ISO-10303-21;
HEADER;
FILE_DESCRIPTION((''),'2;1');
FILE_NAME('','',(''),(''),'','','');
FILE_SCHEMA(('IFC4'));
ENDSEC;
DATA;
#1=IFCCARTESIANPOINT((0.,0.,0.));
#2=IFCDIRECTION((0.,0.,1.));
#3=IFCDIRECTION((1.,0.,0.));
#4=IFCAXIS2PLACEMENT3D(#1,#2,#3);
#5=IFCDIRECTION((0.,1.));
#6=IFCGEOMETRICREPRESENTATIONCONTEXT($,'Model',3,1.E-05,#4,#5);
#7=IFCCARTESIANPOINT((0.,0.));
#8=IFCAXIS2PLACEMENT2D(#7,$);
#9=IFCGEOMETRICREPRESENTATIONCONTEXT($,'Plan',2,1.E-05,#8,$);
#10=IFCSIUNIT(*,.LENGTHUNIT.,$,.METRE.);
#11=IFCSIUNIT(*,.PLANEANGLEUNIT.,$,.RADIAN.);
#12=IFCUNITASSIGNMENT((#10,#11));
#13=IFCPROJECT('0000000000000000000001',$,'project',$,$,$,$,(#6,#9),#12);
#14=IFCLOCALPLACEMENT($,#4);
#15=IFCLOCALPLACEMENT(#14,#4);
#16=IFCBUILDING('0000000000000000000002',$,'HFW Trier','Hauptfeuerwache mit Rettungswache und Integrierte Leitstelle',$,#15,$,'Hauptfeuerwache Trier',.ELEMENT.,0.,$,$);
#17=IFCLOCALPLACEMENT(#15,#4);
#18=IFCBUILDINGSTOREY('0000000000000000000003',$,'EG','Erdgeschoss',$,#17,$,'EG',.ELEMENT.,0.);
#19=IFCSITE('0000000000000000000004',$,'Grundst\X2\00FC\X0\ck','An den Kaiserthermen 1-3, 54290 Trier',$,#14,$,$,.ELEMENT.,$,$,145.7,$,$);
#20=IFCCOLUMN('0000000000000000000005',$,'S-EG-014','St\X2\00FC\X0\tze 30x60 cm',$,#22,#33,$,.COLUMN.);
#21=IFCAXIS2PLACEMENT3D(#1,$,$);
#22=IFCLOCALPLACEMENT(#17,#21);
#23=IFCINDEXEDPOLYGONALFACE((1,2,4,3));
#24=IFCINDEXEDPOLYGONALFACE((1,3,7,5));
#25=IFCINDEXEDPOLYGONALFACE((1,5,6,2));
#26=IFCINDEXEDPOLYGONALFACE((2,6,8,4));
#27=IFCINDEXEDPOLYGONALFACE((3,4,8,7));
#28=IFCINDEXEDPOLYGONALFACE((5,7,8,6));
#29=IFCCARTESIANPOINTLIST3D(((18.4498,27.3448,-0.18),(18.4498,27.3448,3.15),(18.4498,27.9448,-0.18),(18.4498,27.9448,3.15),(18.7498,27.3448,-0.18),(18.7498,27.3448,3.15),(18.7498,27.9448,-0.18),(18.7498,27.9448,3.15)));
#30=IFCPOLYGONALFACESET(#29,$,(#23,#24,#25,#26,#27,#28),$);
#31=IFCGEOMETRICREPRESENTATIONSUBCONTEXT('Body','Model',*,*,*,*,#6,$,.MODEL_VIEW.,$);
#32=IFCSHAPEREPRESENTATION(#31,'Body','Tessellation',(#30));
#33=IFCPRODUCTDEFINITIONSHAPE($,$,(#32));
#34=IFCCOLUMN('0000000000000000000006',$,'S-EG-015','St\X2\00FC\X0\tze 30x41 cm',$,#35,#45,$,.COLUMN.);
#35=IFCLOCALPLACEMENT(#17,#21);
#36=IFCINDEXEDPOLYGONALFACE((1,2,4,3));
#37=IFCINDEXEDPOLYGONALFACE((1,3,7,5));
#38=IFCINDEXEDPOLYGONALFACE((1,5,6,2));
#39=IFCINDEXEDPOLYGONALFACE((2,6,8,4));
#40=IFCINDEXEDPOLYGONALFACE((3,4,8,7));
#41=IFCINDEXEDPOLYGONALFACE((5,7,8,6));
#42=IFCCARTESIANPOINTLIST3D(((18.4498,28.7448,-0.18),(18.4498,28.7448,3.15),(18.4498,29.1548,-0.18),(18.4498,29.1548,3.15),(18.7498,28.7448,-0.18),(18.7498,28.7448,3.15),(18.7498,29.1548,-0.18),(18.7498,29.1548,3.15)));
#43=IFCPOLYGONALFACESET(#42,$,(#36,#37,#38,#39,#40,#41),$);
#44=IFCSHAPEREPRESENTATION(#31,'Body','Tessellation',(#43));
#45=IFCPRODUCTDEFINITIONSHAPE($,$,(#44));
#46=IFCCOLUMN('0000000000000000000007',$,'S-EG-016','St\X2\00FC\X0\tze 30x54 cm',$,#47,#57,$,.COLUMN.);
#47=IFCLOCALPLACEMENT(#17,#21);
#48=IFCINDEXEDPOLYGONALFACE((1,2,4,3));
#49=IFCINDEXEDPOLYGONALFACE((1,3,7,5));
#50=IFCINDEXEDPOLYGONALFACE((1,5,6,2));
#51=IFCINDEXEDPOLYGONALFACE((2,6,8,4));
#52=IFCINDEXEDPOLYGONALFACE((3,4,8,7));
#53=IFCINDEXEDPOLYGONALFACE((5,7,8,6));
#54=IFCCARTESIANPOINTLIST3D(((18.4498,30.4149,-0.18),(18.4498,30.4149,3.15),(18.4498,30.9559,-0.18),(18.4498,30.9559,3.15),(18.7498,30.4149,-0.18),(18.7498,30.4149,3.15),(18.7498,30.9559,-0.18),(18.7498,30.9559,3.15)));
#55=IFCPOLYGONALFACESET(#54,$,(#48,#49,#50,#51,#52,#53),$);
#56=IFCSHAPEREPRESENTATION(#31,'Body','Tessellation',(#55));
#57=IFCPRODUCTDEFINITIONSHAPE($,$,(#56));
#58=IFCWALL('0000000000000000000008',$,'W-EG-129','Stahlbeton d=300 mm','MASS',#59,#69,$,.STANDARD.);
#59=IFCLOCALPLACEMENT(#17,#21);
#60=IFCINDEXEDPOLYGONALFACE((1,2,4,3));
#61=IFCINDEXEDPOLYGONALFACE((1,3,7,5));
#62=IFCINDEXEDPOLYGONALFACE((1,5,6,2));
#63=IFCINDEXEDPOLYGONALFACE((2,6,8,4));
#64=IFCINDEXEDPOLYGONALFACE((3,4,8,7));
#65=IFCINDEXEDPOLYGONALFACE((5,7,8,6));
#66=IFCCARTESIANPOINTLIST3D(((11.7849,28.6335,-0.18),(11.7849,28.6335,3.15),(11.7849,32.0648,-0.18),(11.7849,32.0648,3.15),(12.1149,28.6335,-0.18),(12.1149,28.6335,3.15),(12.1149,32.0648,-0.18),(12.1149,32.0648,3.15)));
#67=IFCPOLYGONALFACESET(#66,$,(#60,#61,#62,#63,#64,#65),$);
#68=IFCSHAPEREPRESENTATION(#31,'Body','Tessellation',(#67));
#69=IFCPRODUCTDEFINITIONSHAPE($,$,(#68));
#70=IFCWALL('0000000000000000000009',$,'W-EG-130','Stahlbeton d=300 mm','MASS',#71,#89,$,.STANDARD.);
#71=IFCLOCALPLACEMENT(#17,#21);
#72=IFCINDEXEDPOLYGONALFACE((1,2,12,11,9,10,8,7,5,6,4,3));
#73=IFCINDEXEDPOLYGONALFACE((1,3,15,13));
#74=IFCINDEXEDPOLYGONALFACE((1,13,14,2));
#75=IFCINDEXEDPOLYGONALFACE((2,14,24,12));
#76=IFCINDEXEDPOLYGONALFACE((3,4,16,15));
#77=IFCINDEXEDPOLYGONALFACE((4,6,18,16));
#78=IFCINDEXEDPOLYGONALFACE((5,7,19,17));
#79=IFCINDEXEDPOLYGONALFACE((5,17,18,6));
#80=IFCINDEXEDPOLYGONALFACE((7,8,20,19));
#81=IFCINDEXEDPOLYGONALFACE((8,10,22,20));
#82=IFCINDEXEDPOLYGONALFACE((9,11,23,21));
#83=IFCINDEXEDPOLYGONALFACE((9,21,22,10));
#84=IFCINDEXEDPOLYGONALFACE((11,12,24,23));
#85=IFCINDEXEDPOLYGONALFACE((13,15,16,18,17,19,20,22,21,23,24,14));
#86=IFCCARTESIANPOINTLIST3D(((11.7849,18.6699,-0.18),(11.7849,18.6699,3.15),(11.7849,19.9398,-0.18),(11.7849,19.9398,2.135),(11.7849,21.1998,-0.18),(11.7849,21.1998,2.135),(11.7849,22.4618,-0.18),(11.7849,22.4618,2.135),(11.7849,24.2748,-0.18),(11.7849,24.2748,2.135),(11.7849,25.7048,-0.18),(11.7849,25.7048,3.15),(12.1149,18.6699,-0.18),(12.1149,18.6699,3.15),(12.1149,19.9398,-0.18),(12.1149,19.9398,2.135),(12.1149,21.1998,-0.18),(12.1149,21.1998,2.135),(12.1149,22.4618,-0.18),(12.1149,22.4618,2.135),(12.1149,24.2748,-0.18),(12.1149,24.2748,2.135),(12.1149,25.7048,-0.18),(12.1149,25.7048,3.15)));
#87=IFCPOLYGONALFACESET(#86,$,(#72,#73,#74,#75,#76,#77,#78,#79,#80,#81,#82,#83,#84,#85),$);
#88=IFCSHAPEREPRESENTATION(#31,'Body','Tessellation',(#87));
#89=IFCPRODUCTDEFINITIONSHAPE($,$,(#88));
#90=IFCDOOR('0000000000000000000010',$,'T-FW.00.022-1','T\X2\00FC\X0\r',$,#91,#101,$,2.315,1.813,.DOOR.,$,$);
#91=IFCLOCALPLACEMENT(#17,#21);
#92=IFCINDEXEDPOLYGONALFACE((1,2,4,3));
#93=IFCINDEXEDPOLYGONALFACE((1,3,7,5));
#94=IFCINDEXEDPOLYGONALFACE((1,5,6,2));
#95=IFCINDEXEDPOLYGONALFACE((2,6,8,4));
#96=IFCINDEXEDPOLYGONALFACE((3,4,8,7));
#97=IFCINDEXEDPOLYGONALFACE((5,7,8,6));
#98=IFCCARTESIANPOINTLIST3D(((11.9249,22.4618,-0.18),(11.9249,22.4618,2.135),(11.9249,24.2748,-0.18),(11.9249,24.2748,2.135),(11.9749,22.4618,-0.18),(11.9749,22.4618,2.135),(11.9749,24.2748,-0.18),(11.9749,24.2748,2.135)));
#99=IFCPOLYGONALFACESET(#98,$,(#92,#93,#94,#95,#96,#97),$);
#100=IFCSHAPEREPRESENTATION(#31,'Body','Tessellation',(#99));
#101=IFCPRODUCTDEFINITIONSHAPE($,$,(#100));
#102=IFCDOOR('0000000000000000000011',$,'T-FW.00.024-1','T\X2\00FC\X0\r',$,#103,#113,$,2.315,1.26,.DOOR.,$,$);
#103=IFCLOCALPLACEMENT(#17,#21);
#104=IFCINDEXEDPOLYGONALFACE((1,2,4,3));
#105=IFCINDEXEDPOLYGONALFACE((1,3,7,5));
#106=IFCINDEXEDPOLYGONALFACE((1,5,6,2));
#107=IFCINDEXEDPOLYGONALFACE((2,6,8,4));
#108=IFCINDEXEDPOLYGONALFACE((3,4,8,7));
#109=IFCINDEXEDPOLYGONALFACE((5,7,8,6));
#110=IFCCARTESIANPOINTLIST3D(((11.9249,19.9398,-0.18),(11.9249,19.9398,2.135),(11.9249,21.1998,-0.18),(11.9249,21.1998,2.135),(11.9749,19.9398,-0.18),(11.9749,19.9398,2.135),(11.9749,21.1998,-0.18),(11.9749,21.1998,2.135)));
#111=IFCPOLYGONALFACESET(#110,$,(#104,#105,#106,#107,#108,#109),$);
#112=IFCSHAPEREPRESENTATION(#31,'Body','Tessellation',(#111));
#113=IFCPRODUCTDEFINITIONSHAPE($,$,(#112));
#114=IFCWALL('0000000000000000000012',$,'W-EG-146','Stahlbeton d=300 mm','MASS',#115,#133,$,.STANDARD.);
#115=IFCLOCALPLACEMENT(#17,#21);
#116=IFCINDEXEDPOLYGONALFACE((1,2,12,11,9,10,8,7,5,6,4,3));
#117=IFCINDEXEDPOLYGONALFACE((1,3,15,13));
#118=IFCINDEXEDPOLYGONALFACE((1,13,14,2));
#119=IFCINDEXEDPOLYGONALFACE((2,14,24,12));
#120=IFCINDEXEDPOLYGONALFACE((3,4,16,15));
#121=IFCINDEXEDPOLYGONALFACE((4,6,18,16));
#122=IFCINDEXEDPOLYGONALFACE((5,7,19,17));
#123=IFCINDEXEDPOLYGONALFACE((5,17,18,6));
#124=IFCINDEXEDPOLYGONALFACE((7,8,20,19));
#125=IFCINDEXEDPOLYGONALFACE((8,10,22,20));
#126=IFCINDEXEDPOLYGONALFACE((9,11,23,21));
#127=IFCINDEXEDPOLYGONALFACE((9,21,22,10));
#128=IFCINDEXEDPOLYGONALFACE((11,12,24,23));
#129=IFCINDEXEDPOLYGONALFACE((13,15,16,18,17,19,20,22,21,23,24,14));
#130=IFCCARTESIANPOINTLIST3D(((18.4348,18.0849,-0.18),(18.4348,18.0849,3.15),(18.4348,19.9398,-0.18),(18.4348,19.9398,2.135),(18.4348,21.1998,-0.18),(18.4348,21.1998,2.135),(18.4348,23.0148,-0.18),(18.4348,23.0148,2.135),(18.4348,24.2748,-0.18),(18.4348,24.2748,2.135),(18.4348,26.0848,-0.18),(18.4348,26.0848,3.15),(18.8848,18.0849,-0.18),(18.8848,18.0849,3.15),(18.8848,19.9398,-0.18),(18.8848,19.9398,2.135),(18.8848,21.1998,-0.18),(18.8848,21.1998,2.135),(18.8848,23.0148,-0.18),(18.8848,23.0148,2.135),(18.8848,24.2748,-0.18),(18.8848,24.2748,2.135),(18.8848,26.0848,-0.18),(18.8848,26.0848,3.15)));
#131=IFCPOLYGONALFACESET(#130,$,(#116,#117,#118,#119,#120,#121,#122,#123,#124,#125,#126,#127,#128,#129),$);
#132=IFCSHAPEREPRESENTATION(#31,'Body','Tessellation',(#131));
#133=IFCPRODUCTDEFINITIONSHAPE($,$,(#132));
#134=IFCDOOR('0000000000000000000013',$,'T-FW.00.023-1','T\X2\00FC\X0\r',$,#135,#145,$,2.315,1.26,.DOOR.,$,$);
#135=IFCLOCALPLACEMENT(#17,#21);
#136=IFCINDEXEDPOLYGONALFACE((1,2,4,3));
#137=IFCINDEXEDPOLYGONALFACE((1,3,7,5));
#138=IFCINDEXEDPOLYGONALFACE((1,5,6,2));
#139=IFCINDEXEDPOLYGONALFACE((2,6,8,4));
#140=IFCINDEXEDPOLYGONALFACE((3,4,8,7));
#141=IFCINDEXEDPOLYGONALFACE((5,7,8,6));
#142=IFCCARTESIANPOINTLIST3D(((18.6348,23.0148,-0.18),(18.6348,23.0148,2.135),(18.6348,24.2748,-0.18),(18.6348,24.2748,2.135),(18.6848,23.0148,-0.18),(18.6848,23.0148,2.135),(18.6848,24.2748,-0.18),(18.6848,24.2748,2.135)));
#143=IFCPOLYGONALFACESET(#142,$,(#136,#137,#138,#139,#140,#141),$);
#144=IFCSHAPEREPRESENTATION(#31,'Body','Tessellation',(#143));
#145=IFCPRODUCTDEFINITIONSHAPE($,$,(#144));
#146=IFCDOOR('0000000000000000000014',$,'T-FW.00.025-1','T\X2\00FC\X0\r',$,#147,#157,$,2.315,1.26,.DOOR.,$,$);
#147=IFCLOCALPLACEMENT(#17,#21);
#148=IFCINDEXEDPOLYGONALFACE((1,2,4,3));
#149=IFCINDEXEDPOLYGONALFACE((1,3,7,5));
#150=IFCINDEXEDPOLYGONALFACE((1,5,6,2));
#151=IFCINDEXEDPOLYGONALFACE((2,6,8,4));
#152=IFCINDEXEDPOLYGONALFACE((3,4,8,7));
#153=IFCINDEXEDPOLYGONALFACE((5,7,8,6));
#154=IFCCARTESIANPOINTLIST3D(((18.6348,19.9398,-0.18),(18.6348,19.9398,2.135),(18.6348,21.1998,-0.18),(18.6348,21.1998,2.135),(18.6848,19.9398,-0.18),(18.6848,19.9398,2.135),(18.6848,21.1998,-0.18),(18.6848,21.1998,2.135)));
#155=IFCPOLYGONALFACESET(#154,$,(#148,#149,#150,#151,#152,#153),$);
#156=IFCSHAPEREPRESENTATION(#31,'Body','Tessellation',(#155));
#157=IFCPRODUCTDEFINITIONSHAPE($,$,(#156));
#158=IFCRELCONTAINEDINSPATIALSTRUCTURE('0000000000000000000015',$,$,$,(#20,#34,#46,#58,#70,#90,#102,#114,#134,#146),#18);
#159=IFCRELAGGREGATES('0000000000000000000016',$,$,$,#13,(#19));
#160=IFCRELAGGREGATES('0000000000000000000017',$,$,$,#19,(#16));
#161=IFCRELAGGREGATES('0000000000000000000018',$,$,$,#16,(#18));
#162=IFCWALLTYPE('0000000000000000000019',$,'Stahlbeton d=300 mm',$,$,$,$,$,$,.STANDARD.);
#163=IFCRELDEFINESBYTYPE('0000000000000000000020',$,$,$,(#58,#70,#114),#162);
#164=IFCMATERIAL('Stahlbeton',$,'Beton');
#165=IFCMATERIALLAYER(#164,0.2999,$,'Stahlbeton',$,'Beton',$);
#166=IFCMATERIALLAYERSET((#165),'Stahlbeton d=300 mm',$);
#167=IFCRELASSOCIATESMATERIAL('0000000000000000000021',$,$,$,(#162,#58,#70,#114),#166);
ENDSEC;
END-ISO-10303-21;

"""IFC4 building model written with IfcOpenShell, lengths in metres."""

from ifc_helpers import new_model, si_unit, direction, frame, frame_2d, origin_with_axes, origin_2d, place, context, subcontext, project, spatial, rectangle, extrude, material, layer, layer_set, layer_usage, type_object, element, fill, save


model = new_model("IFC4")

# Units and contexts
model_context = context("Model", 3, precision=1e-05, world=origin_with_axes(), true_north=direction((0.0, 1.0)))
plan_context = context("Plan", 2, precision=1e-05, world=origin_2d())
body_context = subcontext(model_context, "Body", "Model", "MODEL_VIEW")
ifc_project = project(units=[si_unit("LENGTHUNIT", "METRE"), si_unit("PLANEANGLEUNIT", "RADIAN")], contexts=[model_context, plan_context])

# Site, building, storey
site_placement = place(None, origin_with_axes())
site = spatial("IfcSite", under=ifc_project, at=site_placement, Name="Grundstück", Description="An den Kaiserthermen 1-3, 54290 Trier", CompositionType="ELEMENT", RefElevation=145.7)
building_placement = place(site_placement, origin_with_axes())
building = spatial("IfcBuilding", under=site, at=building_placement, Name="HFW Trier", Description="Hauptfeuerwache mit Rettungswache und Integrierte Leitstelle", LongName="Hauptfeuerwache Trier", CompositionType="ELEMENT", ElevationOfRefHeight=0.0)
storey_placement = place(building_placement, origin_with_axes())
storey = spatial("IfcBuildingStorey", under=building, at=storey_placement, Name="EG", Description="Erdgeschoss", LongName="EG", CompositionType="ELEMENT", Elevation=0.0)

# Columns
column_1_placement = place(storey_placement, frame((18.4498, 27.6448, -0.18), z_axis=(0.0, 0.0, 1.0), x_axis=(1.0, 0.0, 0.0)))
element("IfcColumn", 1, at=column_1_placement, inside=storey, Name="S-EG-014", Description="Stütze 30x60 cm", PredefinedType="COLUMN", context=body_context, shape_type="SweptSolid", body=[
    extrude(rectangle(XDim=0.3, YDim=0.6, at=frame_2d((0.15, 0.0))), origin_with_axes(), (0.0, 0.0, 1.0), 3.33),
])
column_2_placement = place(storey_placement, frame((18.4498, 28.9498, -0.18), z_axis=(0.0, 0.0, 1.0), x_axis=(1.0, 0.0, 0.0)))
element("IfcColumn", 2, at=column_2_placement, inside=storey, Name="S-EG-015", Description="Stütze 30x41 cm", PredefinedType="COLUMN", context=body_context, shape_type="SweptSolid", body=[
    extrude(rectangle(XDim=0.3, YDim=0.41, at=frame_2d((0.15, 0.0))), origin_with_axes(), (0.0, 0.0, 1.0), 3.33),
])
column_3_placement = place(storey_placement, frame((18.4498, 30.6854, -0.18), z_axis=(0.0, 0.0, 1.0), x_axis=(1.0, 0.0, 0.0)))
element("IfcColumn", 3, at=column_3_placement, inside=storey, Name="S-EG-016", Description="Stütze 30x54 cm", PredefinedType="COLUMN", context=body_context, shape_type="SweptSolid", body=[
    extrude(rectangle(XDim=0.3, YDim=0.541, at=frame_2d((0.15, 0.0))), origin_with_axes(), (0.0, 0.0, 1.0), 3.33),
])

# Wall
ifc_material_1 = material(Name="Stahlbeton", Category="Beton")
ifc_layer_1 = layer(ifc_material_1, 0.2999, Name="Stahlbeton", Category="Beton")
ifc_layer_set_1 = layer_set([ifc_layer_1], Name="Stahlbeton d=300 mm")
ifc_layer_usage_1 = layer_usage(ifc_layer_set_1, "AXIS2", "POSITIVE", -0.165)
wall_type_1 = type_object("IfcWallType", Name="Stahlbeton d=300 mm", PredefinedType="STANDARD", material=ifc_layer_set_1)
wall_1_placement = place(storey_placement, frame((11.9499, 32.0648, -0.18), z_axis=(0.0, 0.0, 1.0), x_axis=(0.0, -1.0, 0.0)))
element("IfcWall", 4, at=wall_1_placement, inside=storey, type_object=wall_type_1, material=ifc_layer_usage_1, Name="W-EG-129", Description="Stahlbeton d=300 mm", ObjectType="MASS", PredefinedType="STANDARD", context=body_context, shape_type="SweptSolid", body=[
    extrude(rectangle(XDim=3.4313, YDim=0.33, at=frame_2d((1.7156, 0.0))), origin_with_axes(), (0.0, 0.0, 1.0), 3.33),
])

# Walls, openings, doors
ifc_layer_usage_2 = layer_usage(ifc_layer_set_1, "AXIS2", "POSITIVE", -0.165)
wall_2_placement = place(storey_placement, frame((11.9499, 25.7048, -0.18), z_axis=(0.0, 0.0, 1.0), x_axis=(0.0, -1.0, 0.0)))
wall_2 = element("IfcWall", 5, at=wall_2_placement, inside=storey, type_object=wall_type_1, material=ifc_layer_usage_2, Name="W-EG-130", Description="Stahlbeton d=300 mm", ObjectType="MASS", PredefinedType="STANDARD", context=body_context, shape_type="SweptSolid", body=[
    extrude(rectangle(XDim=7.0349, YDim=0.33, at=frame_2d((3.5175, 0.0))), origin_with_axes(), (0.0, 0.0, 1.0), 3.33),
])
opening_1_placement = place(wall_2_placement, frame((1.43, 0.0, 0.0), z_axis=(0.0, 0.0, 1.0), x_axis=(1.0, 0.0, 0.0)))
opening_1 = element("IfcOpeningElement", 6, at=opening_1_placement, cuts=wall_2, PredefinedType="OPENING", context=body_context, shape_type="SweptSolid", body=[
    extrude(rectangle(XDim=1.813, YDim=0.43, at=frame_2d((0.9065, 0.0))), origin_with_axes(), (0.0, 0.0, 1.0), 2.315),
])
opening_2_placement = place(wall_2_placement, frame((4.505, 0.0, 0.0), z_axis=(0.0, 0.0, 1.0), x_axis=(1.0, 0.0, 0.0)))
opening_2 = element("IfcOpeningElement", 7, at=opening_2_placement, cuts=wall_2, PredefinedType="OPENING", context=body_context, shape_type="SweptSolid", body=[
    extrude(rectangle(XDim=1.26, YDim=0.43, at=frame_2d((0.63, 0.0))), origin_with_axes(), (0.0, 0.0, 1.0), 2.315),
])
door_1_placement = place(wall_2_placement, frame((1.43, 0.0, 0.0), z_axis=(0.0, 0.0, 1.0), x_axis=(1.0, 0.0, 0.0)))
door_1 = element("IfcDoor", 8, at=door_1_placement, inside=storey, Name="T-FW.00.022-1", Description="Tür", OverallHeight=2.315, OverallWidth=1.813, PredefinedType="DOOR", context=body_context, shape_type="SweptSolid", body=[
    extrude(rectangle(XDim=1.813, YDim=0.05, at=frame_2d((0.9065, 0.0))), origin_with_axes(), (0.0, 0.0, 1.0), 2.315),
])
fill(opening_1, door_1)
door_2_placement = place(wall_2_placement, frame((4.505, 0.0, 0.0), z_axis=(0.0, 0.0, 1.0), x_axis=(1.0, 0.0, 0.0)))
door_2 = element("IfcDoor", 9, at=door_2_placement, inside=storey, Name="T-FW.00.024-1", Description="Tür", OverallHeight=2.315, OverallWidth=1.26, PredefinedType="DOOR", context=body_context, shape_type="SweptSolid", body=[
    extrude(rectangle(XDim=1.26, YDim=0.05, at=frame_2d((0.63, 0.0))), origin_with_axes(), (0.0, 0.0, 1.0), 2.315),
])
fill(opening_2, door_2)
ifc_layer_usage_3 = layer_usage(ifc_layer_set_1, "AXIS2", "POSITIVE", -0.225)
wall_3_placement = place(storey_placement, frame((18.6598, 26.0848, -0.18), z_axis=(0.0, 0.0, 1.0), x_axis=(0.0, -1.0, 0.0)))
wall_3 = element("IfcWall", 10, at=wall_3_placement, inside=storey, type_object=wall_type_1, material=ifc_layer_usage_3, Name="W-EG-146", Description="Stahlbeton d=300 mm", ObjectType="MASS", PredefinedType="STANDARD", context=body_context, shape_type="SweptSolid", body=[
    extrude(rectangle(XDim=7.9999, YDim=0.45, at=frame_2d((4.0, 0.0))), origin_with_axes(), (0.0, 0.0, 1.0), 3.33),
])
opening_3_placement = place(wall_3_placement, frame((1.81, 0.0, 0.0), z_axis=(0.0, 0.0, 1.0), x_axis=(1.0, 0.0, 0.0)))
opening_3 = element("IfcOpeningElement", 11, at=opening_3_placement, cuts=wall_3, PredefinedType="OPENING", context=body_context, shape_type="SweptSolid", body=[
    extrude(rectangle(XDim=1.26, YDim=0.55, at=frame_2d((0.63, 0.0))), origin_with_axes(), (0.0, 0.0, 1.0), 2.315),
])
opening_4_placement = place(wall_3_placement, frame((4.885, 0.0, 0.0), z_axis=(0.0, 0.0, 1.0), x_axis=(1.0, 0.0, 0.0)))
opening_4 = element("IfcOpeningElement", 12, at=opening_4_placement, cuts=wall_3, PredefinedType="OPENING", context=body_context, shape_type="SweptSolid", body=[
    extrude(rectangle(XDim=1.26, YDim=0.55, at=frame_2d((0.63, 0.0))), origin_with_axes(), (0.0, 0.0, 1.0), 2.315),
])
door_3_placement = place(wall_3_placement, frame((1.81, 0.0, 0.0), z_axis=(0.0, 0.0, 1.0), x_axis=(1.0, 0.0, 0.0)))
door_3 = element("IfcDoor", 13, at=door_3_placement, inside=storey, Name="T-FW.00.023-1", Description="Tür", OverallHeight=2.315, OverallWidth=1.26, PredefinedType="DOOR", context=body_context, shape_type="SweptSolid", body=[
    extrude(rectangle(XDim=1.26, YDim=0.05, at=frame_2d((0.63, 0.0))), origin_with_axes(), (0.0, 0.0, 1.0), 2.315),
])
fill(opening_3, door_3)
door_4_placement = place(wall_3_placement, frame((4.885, 0.0, 0.0), z_axis=(0.0, 0.0, 1.0), x_axis=(1.0, 0.0, 0.0)))
door_4 = element("IfcDoor", 14, at=door_4_placement, inside=storey, Name="T-FW.00.025-1", Description="Tür", OverallHeight=2.315, OverallWidth=1.26, PredefinedType="DOOR", context=body_context, shape_type="SweptSolid", body=[
    extrude(rectangle(XDim=1.26, YDim=0.05, at=frame_2d((0.63, 0.0))), origin_with_axes(), (0.0, 0.0, 1.0), 2.315),
])
fill(opening_4, door_4)

save(model, "model.ifc")
